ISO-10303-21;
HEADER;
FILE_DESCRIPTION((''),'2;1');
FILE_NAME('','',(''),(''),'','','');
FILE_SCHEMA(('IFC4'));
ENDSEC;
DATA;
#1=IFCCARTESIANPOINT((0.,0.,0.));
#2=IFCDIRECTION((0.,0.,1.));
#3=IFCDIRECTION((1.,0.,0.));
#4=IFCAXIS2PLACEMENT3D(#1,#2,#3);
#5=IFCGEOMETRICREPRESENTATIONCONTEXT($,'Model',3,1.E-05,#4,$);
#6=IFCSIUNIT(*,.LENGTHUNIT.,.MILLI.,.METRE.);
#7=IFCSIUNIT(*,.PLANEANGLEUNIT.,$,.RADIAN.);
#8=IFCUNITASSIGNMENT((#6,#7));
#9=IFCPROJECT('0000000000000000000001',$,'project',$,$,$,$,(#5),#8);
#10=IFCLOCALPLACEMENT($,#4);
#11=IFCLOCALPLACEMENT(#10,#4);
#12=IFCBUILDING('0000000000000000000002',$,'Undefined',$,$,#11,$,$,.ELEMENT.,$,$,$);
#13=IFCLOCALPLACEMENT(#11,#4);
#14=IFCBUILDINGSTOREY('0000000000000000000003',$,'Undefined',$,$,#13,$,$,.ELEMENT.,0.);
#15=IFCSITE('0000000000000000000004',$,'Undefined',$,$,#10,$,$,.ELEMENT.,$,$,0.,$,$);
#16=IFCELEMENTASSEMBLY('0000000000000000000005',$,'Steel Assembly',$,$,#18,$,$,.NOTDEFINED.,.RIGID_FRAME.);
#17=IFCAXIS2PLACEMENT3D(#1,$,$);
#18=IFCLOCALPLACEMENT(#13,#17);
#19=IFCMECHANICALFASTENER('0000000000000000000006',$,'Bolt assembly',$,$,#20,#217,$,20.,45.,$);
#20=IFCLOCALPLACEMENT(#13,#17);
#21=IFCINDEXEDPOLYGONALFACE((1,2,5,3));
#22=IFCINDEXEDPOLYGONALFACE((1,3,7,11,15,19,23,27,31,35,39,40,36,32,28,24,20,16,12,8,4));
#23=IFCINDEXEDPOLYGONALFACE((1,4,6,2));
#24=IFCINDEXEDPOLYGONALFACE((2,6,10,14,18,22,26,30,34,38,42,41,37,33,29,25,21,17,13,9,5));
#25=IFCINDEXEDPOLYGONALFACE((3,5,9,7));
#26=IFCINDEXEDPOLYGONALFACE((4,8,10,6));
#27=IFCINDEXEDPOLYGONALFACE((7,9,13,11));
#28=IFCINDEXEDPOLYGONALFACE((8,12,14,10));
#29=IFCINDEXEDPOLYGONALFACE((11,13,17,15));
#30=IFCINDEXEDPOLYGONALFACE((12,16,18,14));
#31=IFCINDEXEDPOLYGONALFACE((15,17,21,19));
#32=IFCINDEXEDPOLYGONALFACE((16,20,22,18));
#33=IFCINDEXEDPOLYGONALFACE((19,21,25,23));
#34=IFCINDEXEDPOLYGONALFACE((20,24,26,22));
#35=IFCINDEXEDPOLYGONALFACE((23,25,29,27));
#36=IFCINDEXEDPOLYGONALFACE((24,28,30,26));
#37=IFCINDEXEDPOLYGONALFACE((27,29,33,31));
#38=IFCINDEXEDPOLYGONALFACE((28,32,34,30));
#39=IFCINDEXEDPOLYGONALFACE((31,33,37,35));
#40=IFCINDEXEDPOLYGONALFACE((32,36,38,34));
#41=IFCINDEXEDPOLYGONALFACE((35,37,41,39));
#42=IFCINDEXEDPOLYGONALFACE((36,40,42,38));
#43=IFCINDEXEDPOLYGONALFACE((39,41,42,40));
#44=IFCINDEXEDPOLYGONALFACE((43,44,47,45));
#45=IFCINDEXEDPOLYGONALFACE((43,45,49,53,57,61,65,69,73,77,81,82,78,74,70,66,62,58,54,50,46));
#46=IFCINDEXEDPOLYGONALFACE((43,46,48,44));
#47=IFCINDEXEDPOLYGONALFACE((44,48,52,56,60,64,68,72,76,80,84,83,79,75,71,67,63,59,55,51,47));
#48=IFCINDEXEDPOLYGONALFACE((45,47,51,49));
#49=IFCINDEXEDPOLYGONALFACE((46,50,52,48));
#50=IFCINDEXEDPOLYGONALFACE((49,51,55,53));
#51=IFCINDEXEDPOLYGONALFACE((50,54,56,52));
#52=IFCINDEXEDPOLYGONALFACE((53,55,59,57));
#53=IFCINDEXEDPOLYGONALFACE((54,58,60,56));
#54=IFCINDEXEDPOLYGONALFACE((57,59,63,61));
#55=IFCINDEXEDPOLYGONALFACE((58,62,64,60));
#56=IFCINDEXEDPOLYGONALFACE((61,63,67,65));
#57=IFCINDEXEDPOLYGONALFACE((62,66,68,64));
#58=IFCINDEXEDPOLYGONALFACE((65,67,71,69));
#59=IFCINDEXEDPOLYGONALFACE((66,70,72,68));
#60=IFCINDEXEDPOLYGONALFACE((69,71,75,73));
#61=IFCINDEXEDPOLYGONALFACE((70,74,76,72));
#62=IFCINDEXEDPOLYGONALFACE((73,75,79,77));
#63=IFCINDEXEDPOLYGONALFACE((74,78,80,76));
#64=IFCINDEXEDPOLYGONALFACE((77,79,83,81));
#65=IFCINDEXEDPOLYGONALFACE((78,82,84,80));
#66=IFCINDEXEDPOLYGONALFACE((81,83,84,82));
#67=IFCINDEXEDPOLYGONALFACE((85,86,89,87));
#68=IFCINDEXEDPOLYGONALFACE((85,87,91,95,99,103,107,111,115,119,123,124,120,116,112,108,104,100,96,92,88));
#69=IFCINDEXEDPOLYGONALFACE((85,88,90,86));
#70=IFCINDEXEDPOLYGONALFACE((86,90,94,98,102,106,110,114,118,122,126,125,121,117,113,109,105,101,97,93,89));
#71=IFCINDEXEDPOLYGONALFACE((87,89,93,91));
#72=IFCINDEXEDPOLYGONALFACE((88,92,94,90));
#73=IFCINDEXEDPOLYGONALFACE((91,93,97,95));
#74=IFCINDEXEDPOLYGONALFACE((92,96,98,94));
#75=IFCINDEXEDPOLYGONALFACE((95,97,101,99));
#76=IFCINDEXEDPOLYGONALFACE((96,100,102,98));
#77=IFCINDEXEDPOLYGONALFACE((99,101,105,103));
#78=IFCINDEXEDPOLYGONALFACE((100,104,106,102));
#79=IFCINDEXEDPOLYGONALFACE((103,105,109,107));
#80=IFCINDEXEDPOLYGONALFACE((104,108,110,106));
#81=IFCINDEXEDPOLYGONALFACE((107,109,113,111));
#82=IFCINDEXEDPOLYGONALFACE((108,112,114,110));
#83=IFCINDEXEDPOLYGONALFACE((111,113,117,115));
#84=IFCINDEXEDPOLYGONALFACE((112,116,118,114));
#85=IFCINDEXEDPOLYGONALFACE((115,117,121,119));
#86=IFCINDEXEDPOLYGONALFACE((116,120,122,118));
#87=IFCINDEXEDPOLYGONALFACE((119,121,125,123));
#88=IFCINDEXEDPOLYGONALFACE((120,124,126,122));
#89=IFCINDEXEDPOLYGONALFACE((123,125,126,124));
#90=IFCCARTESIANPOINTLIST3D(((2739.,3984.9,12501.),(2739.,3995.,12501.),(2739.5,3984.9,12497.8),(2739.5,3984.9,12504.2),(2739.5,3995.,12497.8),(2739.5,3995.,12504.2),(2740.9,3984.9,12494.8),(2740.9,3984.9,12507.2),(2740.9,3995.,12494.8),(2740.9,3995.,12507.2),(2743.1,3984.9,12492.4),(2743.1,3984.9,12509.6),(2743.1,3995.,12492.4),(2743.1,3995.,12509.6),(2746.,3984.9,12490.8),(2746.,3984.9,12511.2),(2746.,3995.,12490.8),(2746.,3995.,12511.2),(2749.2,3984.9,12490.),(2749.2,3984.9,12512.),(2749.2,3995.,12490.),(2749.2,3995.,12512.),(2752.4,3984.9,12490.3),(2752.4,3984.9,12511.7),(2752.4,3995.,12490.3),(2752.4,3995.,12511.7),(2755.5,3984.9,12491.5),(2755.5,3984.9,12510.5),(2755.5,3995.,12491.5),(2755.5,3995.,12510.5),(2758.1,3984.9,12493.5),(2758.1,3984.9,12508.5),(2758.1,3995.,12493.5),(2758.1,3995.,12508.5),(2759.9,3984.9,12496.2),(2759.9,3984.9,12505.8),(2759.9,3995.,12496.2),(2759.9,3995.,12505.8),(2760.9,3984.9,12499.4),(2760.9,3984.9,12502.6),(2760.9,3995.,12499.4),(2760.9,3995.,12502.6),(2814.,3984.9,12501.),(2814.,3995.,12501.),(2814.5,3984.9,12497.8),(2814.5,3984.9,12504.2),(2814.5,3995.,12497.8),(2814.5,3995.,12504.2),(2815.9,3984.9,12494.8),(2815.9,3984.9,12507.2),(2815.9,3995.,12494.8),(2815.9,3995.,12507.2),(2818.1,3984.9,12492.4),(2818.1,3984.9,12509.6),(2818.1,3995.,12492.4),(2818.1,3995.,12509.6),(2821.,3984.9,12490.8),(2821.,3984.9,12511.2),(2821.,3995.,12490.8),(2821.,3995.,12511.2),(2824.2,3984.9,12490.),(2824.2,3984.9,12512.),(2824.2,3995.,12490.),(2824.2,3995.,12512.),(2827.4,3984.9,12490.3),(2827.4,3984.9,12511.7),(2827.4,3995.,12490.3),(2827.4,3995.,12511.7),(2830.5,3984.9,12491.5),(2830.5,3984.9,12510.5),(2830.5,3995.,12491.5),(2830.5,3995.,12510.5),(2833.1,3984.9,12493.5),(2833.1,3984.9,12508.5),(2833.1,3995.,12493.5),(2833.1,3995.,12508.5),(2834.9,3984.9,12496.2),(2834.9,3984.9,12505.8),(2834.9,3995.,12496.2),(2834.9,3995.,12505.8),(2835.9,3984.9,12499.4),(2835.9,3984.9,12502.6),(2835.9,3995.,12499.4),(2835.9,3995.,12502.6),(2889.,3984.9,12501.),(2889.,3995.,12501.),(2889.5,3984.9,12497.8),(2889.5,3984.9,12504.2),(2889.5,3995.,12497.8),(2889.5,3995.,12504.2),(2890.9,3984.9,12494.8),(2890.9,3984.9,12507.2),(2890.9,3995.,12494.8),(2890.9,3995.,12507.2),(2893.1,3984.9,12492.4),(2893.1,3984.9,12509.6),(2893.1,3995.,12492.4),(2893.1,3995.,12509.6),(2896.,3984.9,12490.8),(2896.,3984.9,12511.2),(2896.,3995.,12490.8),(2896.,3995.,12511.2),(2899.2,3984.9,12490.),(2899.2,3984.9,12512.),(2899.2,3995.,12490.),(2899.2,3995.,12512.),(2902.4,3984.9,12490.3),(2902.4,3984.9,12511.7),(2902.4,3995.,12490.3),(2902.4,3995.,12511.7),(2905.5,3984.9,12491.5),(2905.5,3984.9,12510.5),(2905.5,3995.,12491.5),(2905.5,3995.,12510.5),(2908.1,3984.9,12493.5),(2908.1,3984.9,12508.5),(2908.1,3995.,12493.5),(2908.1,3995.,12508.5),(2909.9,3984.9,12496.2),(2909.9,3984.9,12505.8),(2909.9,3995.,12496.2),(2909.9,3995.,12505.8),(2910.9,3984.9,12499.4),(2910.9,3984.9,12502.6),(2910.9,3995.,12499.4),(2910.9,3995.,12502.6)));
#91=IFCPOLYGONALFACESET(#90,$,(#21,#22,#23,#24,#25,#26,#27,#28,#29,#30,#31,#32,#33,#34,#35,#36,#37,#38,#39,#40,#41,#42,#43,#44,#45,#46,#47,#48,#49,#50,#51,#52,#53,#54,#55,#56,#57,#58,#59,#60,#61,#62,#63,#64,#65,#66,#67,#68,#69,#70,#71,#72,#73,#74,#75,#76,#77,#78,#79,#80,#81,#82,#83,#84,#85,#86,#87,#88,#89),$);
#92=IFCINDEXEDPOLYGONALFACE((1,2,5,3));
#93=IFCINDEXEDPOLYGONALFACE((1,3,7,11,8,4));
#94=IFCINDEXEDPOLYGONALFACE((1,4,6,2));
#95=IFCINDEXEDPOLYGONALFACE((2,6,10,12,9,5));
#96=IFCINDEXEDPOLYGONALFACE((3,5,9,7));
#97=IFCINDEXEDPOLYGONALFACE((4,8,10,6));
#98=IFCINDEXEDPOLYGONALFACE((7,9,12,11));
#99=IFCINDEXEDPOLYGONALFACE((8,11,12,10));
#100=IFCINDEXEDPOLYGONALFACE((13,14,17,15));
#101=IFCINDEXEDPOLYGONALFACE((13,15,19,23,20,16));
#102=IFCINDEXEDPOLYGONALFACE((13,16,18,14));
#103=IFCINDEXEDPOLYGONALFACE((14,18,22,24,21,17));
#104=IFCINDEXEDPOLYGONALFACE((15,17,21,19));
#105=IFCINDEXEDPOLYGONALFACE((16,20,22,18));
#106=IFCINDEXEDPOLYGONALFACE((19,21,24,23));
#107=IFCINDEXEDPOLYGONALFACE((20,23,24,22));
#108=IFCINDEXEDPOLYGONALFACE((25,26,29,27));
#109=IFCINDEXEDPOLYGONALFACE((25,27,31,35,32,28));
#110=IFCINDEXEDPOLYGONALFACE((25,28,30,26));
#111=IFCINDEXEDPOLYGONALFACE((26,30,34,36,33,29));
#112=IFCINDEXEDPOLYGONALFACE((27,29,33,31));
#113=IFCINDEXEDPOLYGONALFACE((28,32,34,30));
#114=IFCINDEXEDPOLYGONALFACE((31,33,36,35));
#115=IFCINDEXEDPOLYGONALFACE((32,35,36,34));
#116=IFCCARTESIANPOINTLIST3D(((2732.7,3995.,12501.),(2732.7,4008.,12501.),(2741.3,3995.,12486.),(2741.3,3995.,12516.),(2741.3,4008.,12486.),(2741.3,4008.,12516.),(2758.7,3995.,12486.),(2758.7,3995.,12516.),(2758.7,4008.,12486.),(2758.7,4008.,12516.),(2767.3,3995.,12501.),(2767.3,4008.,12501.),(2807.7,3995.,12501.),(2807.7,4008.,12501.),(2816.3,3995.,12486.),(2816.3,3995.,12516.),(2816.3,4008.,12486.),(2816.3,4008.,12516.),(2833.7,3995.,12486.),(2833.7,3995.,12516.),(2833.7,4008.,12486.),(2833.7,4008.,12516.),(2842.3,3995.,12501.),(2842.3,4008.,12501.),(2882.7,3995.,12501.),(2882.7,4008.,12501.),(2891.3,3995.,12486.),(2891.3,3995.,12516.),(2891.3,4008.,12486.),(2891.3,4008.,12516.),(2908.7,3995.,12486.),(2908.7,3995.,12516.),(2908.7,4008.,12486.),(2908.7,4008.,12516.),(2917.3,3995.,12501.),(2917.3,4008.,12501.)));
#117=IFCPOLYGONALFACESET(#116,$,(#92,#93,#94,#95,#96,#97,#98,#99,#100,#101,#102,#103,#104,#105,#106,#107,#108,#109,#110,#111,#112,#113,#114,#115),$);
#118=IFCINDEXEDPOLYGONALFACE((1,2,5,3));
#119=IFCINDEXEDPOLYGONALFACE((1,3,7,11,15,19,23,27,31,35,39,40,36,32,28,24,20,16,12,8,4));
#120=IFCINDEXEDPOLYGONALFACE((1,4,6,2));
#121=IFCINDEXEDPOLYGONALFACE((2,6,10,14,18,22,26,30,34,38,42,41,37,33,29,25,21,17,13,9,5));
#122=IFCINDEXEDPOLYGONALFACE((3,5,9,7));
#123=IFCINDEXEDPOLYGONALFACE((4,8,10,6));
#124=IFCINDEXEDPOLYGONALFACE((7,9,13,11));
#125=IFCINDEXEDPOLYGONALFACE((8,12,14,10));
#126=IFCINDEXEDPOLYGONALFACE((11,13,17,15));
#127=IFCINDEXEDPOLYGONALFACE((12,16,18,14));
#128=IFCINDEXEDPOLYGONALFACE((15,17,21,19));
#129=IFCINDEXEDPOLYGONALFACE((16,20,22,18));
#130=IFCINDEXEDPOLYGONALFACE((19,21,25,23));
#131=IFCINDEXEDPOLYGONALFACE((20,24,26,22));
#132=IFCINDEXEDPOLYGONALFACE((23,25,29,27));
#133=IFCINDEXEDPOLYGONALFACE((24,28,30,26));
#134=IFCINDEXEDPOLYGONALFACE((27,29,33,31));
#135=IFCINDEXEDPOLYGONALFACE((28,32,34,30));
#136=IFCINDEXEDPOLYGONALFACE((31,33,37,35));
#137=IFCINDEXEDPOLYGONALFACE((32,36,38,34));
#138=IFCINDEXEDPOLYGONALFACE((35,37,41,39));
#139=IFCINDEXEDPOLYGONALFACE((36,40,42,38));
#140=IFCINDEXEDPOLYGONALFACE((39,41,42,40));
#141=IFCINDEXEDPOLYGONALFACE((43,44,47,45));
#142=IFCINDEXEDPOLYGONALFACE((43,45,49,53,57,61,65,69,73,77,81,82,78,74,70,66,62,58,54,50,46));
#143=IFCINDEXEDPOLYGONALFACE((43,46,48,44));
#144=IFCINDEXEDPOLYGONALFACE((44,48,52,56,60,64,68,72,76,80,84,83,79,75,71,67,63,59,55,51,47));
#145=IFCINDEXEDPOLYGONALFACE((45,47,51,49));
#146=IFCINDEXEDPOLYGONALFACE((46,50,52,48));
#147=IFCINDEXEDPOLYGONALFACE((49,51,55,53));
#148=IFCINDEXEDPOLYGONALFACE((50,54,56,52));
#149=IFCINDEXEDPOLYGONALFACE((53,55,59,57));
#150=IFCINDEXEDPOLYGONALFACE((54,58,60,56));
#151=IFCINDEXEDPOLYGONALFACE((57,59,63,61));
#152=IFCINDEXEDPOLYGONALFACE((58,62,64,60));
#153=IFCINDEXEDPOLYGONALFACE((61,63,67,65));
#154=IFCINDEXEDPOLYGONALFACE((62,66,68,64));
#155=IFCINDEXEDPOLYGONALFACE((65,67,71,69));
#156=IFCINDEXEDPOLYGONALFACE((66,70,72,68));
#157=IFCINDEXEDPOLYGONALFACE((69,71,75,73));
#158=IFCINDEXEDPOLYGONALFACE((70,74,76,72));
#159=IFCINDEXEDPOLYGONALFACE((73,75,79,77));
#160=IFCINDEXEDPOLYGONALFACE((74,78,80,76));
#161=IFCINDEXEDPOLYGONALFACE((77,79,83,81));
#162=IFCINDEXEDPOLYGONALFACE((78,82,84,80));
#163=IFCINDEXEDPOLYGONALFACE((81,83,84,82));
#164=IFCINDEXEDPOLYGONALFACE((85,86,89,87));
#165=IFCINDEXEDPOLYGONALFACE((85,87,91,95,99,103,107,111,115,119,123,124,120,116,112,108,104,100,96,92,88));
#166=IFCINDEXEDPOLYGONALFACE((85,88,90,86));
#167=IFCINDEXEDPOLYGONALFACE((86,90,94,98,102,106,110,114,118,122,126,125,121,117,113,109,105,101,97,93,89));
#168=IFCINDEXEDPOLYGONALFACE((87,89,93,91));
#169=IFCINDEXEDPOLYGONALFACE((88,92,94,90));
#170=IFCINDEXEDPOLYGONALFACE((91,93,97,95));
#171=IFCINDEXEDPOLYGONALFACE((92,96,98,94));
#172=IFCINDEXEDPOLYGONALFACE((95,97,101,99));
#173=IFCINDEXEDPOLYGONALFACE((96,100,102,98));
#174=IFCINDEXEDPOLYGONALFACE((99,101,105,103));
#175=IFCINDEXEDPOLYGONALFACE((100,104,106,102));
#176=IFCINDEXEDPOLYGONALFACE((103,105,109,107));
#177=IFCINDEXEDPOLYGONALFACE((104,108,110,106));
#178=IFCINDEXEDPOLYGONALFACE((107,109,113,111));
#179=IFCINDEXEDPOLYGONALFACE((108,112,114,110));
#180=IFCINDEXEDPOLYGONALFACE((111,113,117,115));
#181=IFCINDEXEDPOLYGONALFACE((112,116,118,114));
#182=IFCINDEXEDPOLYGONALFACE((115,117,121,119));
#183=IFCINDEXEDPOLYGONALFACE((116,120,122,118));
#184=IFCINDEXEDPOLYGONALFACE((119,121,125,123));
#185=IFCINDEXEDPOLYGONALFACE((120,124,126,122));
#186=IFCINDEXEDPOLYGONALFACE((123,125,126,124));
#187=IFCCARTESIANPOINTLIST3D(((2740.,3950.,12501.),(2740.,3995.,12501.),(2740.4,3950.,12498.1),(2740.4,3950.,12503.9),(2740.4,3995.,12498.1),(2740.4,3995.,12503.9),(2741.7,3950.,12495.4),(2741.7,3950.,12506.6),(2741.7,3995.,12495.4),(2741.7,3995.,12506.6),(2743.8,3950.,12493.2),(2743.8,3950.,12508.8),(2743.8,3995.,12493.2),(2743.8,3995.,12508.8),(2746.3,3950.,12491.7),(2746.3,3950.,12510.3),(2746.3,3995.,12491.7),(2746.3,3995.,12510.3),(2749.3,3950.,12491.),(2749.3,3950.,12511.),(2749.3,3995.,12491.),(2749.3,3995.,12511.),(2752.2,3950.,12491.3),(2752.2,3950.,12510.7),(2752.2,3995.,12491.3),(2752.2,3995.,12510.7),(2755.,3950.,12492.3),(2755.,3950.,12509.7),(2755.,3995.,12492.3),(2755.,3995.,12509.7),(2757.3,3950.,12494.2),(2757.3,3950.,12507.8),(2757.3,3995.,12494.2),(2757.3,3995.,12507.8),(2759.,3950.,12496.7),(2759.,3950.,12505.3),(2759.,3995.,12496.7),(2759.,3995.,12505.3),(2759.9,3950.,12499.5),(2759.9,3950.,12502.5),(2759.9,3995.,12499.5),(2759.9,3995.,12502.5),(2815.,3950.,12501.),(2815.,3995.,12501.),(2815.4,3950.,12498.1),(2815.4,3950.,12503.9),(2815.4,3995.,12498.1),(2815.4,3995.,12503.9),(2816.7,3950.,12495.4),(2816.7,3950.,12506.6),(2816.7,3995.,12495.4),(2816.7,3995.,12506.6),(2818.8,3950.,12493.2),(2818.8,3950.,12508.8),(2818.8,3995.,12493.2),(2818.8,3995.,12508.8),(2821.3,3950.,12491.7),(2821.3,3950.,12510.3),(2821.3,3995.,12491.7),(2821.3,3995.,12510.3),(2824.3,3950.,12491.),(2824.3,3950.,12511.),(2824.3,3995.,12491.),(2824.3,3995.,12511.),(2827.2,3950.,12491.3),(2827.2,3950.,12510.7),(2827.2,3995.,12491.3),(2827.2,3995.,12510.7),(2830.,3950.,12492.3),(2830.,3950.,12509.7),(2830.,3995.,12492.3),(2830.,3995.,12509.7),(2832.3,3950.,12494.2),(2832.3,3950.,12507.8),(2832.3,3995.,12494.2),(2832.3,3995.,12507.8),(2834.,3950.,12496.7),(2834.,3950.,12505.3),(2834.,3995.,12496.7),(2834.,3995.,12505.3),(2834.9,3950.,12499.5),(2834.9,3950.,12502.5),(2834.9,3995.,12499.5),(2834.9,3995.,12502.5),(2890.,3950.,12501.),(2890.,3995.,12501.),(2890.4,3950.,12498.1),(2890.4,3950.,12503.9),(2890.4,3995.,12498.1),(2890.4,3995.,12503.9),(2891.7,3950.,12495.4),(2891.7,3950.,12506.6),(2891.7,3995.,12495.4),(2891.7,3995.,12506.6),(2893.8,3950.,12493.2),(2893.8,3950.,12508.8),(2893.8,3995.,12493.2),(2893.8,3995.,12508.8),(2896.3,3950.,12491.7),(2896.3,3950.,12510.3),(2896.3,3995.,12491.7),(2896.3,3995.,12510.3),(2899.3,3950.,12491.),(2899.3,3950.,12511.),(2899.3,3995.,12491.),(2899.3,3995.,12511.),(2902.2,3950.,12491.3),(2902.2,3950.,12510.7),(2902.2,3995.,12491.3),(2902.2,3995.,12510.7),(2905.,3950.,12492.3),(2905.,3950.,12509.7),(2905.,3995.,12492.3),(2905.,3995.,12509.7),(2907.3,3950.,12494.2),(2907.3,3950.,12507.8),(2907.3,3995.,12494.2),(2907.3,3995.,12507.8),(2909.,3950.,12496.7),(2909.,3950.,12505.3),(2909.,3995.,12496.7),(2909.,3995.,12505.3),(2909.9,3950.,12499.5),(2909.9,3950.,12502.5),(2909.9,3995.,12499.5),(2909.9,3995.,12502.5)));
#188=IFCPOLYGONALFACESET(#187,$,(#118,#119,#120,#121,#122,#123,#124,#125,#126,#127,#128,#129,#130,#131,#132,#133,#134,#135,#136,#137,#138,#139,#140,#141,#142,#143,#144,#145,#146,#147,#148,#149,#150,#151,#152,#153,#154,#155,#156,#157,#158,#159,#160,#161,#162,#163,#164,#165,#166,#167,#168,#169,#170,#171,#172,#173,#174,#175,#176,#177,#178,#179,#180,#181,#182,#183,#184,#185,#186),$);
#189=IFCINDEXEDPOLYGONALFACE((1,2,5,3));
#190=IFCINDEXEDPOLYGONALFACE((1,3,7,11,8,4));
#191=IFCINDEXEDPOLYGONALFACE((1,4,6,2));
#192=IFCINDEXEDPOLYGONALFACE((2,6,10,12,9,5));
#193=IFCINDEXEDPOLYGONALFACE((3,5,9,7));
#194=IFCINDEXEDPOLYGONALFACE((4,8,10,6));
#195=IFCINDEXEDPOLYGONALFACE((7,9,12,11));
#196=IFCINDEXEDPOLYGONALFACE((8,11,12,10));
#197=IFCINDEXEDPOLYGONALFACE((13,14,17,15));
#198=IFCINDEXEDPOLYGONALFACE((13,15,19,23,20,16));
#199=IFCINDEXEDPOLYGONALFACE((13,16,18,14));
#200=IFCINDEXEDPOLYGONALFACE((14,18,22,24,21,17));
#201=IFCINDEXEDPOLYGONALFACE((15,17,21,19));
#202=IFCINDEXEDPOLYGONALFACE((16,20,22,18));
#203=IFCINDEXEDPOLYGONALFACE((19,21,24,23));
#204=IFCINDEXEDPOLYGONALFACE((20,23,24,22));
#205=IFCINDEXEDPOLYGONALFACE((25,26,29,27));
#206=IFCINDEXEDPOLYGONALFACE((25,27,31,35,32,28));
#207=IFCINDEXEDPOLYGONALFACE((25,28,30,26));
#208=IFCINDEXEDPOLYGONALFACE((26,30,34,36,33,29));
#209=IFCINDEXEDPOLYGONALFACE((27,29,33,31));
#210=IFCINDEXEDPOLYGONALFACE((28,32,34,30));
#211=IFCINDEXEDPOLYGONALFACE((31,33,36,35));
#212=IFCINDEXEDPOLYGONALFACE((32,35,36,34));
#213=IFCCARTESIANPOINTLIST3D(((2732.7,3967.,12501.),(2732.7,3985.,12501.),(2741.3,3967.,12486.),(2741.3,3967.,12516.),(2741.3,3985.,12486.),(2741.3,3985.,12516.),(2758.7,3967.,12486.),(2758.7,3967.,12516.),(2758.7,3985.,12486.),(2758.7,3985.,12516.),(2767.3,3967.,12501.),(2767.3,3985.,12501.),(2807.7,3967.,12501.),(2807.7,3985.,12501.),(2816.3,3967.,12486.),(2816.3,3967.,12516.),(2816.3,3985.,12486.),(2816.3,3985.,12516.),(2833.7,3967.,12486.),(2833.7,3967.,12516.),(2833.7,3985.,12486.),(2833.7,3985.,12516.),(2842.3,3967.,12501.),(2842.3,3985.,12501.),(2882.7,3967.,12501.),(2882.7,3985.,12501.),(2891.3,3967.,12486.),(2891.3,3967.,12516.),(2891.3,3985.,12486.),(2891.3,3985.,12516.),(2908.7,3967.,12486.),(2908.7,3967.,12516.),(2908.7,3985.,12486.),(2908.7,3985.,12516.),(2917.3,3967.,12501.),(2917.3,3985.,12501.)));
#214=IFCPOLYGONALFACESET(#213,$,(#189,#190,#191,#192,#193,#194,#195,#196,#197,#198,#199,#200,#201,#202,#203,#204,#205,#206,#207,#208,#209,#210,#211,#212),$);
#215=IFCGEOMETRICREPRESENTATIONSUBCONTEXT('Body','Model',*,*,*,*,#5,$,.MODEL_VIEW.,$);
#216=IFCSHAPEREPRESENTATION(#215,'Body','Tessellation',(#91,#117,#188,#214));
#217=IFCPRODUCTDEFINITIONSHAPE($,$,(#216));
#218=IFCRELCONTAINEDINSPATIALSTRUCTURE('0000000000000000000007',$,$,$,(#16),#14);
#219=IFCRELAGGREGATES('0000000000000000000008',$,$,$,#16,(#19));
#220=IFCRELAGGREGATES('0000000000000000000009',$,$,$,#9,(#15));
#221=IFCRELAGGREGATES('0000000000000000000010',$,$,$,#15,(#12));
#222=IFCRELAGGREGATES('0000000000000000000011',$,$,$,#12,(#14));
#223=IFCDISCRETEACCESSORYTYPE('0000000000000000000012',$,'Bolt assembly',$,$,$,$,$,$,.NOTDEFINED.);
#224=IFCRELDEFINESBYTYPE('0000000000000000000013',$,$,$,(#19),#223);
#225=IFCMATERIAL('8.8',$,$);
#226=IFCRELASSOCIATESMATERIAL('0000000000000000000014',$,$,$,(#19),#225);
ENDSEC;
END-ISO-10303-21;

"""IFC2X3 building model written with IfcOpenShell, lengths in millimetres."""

from ifc_helpers import new_model, si_unit, frame, origin_with_axes, origin_2d_with_axis, place, context, subcontext, project, spatial, polyline, circle, outline, extrude, source, transform, mapped, material, type_object, element, aggregate, save


model = new_model("IFC2X3")

# Units and contexts
model_context = context("Model", 3, precision=1e-05, world=origin_with_axes())
body_context = subcontext(model_context, "Body", "Model", "MODEL_VIEW")
ifc_project = project(units=[si_unit("LENGTHUNIT", "METRE", prefix="MILLI"), si_unit("PLANEANGLEUNIT", "RADIAN")], contexts=[model_context])

# Site, building, storey
site_placement = place(None, origin_with_axes())
site = spatial("IfcSite", under=ifc_project, at=site_placement, Name="Undefined", CompositionType="ELEMENT", RefElevation=0.0)
building_placement = place(site_placement, origin_with_axes())
building = spatial("IfcBuilding", under=site, at=building_placement, Name="Undefined", CompositionType="ELEMENT")
storey_placement = place(building_placement, origin_with_axes())
storey = spatial("IfcBuildingStorey", under=building, at=storey_placement, Name="Undefined", CompositionType="ELEMENT", Elevation=0.0)

# Element assembly
assembly_1_placement = place(storey_placement, origin_with_axes())
assembly_1 = element("IfcElementAssembly", 1, at=assembly_1_placement, inside=storey, Name="Steel Assembly", AssemblyPlace="NOTDEFINED", PredefinedType="RIGID_FRAME")

# Shared definitions
ifc_material_1 = material(Name="8.8")
discrete_accessory_type_1 = type_object("IfcDiscreteAccessoryType", Name="Bolt assembly")

# Mechanical fastener
shared_shape_1 = source(origin_with_axes(), body_context, "Body", "SweptSolid", [
    extrude(circle(Radius=11.0, at=origin_2d_with_axis()), frame((0.0, 5.0, 0.0), z_axis=(0.0, 1.0, 0.0), x_axis=(1.0, 0.0, 0.0)), (0.0, 0.0, 1.0), 10.1),
    extrude(outline(polyline([(17.3, 0.0), (8.7, 15.0), (-8.7, 15.0), (-17.3, 0.0), (-8.7, -15.0), (8.7, -15.0), (17.3, 0.0)])), frame((0.0, -8.0, 0.0), z_axis=(0.0, 1.0, 0.0), x_axis=(1.0, 0.0, 0.0)), (0.0, 0.0, 1.0), 13.0),
    extrude(circle(Radius=10.0, at=origin_2d_with_axis()), frame((0.0, 5.0, 0.0), z_axis=(0.0, 1.0, 0.0), x_axis=(1.0, 0.0, 0.0)), (0.0, 0.0, 1.0), 45.0),
    extrude(outline(polyline([(17.3, 0.0), (8.7, 15.0), (-8.7, 15.0), (-17.3, 0.0), (-8.7, -15.0), (8.7, -15.0), (17.3, 0.0)])), frame((0.0, 15.0, 0.0), z_axis=(0.0, 1.0, 0.0), x_axis=(1.0, 0.0, 0.0)), (0.0, 0.0, 1.0), 18.0),
])
mechanical_fastener_1_placement = place(assembly_1_placement, frame((2900.0, 4000.0, 12501.0), z_axis=(0.0, 0.0, 1.0), x_axis=(-1.0, 0.0, 0.0)))
mechanical_fastener_1 = element("IfcMechanicalFastener", 2, at=mechanical_fastener_1_placement, type_object=discrete_accessory_type_1, material=ifc_material_1, Name="Bolt assembly", NominalDiameter=20.0, NominalLength=45.0, context=body_context, shape_type="MappedRepresentation", body=[
    mapped(shared_shape_1, transform((0.0, 0.0, 0.0))),
    mapped(shared_shape_1, transform((75.0, 0.0, 0.0))),
    mapped(shared_shape_1, transform((150.0, 0.0, 0.0))),
])
aggregate(assembly_1, [mechanical_fastener_1])

save(model, "model.ifc")
